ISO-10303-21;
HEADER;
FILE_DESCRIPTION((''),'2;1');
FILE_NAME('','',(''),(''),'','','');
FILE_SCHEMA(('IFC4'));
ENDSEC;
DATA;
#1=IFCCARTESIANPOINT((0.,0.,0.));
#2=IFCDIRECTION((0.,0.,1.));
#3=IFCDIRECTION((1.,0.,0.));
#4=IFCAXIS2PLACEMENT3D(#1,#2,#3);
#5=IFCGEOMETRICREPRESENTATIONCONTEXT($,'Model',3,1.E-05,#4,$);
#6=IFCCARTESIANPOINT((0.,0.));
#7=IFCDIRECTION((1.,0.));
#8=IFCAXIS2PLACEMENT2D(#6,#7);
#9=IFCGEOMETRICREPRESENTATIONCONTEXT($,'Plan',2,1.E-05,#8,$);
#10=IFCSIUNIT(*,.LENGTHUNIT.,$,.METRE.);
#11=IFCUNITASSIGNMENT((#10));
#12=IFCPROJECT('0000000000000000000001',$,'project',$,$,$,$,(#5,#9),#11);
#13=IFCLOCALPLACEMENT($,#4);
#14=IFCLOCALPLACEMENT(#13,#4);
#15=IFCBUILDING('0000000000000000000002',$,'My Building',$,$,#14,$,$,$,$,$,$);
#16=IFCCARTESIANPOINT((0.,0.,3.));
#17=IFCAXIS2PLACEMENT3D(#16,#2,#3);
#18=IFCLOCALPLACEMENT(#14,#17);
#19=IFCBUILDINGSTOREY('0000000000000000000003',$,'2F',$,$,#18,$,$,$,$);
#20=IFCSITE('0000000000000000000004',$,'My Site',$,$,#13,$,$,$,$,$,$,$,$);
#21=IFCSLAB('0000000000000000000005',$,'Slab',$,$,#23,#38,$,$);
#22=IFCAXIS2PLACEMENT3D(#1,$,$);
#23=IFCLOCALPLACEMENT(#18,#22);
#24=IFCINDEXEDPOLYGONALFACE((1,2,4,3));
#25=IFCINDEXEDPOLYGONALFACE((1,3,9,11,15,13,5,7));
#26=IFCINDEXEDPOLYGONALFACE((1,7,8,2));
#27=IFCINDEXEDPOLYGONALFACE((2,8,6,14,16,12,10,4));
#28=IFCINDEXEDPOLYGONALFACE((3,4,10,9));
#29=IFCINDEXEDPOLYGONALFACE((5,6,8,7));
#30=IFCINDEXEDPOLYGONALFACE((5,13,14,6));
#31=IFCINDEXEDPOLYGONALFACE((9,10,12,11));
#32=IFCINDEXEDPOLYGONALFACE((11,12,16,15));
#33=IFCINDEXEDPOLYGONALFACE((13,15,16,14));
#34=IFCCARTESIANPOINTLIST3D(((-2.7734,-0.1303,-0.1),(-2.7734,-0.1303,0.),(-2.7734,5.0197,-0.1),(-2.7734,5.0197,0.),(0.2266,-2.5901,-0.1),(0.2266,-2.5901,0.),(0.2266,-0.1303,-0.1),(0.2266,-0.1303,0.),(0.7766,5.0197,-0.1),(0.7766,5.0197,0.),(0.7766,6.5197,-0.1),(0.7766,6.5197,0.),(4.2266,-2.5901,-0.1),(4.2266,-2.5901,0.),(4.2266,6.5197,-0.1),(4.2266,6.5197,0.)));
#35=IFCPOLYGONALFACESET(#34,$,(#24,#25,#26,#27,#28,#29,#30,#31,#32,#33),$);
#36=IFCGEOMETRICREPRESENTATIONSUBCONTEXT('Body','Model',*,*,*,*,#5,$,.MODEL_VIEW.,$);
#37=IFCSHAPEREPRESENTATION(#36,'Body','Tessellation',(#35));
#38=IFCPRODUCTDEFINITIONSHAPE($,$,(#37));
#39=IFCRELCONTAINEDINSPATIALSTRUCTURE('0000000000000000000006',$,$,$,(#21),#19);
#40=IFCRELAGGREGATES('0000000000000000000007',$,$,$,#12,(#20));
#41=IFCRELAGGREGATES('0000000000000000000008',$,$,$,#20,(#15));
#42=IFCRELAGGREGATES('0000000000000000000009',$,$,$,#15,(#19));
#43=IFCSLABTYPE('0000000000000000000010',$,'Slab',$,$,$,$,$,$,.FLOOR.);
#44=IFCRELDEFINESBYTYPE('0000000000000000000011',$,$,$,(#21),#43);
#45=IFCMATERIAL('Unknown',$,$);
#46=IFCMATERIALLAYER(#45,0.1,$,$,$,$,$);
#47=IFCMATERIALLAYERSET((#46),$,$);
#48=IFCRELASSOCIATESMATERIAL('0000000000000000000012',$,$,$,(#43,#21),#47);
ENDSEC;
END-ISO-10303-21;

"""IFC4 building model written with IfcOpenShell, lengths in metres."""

from ifc_helpers import new_model, si_unit, frame, origin_with_axes, origin_2d_with_axis, place, context, subcontext, project, spatial, indexed_curve, outline, extrude, material, layer, layer_set, layer_usage, type_object, element, save


model = new_model("IFC4")

# Units and contexts
model_context = context("Model", 3, precision=1e-05, world=origin_with_axes())
plan_context = context("Plan", 2, precision=1e-05, world=origin_2d_with_axis())
body_context = subcontext(model_context, "Body", "Model", "MODEL_VIEW")
ifc_project = project(units=[si_unit("LENGTHUNIT", "METRE")], contexts=[model_context, plan_context])

# Site, building, storey
site_placement = place(None, origin_with_axes())
site = spatial("IfcSite", under=ifc_project, at=site_placement, Name="My Site")
building_placement = place(site_placement, origin_with_axes())
building = spatial("IfcBuilding", under=site, at=building_placement, Name="My Building")
storey_placement = place(building_placement, frame((0.0, 0.0, 3.0), z_axis=(0.0, 0.0, 1.0), x_axis=(1.0, 0.0, 0.0)))
storey = spatial("IfcBuildingStorey", under=building, at=storey_placement, Name="2F")

# Slab
ifc_material = material(Name="Unknown")
ifc_layer = layer(ifc_material, 0.1)
ifc_layer_set = layer_set([ifc_layer])
ifc_layer_usage = layer_usage(ifc_layer_set, "AXIS3", "POSITIVE", -0.1)
slab_type = type_object("IfcSlabType", Name="Slab", PredefinedType="FLOOR", material=ifc_layer_set)
slab_placement = place(storey_placement, frame((4.2266, -2.5901, 0.0), z_axis=(0.0, 0.0, 1.0), x_axis=(1.0, 0.0, 0.0)))
element("IfcSlab", 1, at=slab_placement, inside=storey, type_object=slab_type, material=ifc_layer_usage, Name="Slab", context=body_context, shape_type="SweptSolid", body=[
    extrude(outline(indexed_curve([(0.0, 0.0), (0.0, 9.1098), (-3.45, 9.1098), (-3.45, 7.6098), (-7.0, 7.6098), (-7.0, 2.4598), (-4.0, 2.4598), (-4.0, 0.0), (0.0, 0.0)])), frame((0.0, 0.0, -0.1), z_axis=(0.0, 0.0, 1.0), x_axis=(1.0, 0.0, 0.0)), (0.0, 0.0, 1.0), 0.1),
])

save(model, "model.ifc")
